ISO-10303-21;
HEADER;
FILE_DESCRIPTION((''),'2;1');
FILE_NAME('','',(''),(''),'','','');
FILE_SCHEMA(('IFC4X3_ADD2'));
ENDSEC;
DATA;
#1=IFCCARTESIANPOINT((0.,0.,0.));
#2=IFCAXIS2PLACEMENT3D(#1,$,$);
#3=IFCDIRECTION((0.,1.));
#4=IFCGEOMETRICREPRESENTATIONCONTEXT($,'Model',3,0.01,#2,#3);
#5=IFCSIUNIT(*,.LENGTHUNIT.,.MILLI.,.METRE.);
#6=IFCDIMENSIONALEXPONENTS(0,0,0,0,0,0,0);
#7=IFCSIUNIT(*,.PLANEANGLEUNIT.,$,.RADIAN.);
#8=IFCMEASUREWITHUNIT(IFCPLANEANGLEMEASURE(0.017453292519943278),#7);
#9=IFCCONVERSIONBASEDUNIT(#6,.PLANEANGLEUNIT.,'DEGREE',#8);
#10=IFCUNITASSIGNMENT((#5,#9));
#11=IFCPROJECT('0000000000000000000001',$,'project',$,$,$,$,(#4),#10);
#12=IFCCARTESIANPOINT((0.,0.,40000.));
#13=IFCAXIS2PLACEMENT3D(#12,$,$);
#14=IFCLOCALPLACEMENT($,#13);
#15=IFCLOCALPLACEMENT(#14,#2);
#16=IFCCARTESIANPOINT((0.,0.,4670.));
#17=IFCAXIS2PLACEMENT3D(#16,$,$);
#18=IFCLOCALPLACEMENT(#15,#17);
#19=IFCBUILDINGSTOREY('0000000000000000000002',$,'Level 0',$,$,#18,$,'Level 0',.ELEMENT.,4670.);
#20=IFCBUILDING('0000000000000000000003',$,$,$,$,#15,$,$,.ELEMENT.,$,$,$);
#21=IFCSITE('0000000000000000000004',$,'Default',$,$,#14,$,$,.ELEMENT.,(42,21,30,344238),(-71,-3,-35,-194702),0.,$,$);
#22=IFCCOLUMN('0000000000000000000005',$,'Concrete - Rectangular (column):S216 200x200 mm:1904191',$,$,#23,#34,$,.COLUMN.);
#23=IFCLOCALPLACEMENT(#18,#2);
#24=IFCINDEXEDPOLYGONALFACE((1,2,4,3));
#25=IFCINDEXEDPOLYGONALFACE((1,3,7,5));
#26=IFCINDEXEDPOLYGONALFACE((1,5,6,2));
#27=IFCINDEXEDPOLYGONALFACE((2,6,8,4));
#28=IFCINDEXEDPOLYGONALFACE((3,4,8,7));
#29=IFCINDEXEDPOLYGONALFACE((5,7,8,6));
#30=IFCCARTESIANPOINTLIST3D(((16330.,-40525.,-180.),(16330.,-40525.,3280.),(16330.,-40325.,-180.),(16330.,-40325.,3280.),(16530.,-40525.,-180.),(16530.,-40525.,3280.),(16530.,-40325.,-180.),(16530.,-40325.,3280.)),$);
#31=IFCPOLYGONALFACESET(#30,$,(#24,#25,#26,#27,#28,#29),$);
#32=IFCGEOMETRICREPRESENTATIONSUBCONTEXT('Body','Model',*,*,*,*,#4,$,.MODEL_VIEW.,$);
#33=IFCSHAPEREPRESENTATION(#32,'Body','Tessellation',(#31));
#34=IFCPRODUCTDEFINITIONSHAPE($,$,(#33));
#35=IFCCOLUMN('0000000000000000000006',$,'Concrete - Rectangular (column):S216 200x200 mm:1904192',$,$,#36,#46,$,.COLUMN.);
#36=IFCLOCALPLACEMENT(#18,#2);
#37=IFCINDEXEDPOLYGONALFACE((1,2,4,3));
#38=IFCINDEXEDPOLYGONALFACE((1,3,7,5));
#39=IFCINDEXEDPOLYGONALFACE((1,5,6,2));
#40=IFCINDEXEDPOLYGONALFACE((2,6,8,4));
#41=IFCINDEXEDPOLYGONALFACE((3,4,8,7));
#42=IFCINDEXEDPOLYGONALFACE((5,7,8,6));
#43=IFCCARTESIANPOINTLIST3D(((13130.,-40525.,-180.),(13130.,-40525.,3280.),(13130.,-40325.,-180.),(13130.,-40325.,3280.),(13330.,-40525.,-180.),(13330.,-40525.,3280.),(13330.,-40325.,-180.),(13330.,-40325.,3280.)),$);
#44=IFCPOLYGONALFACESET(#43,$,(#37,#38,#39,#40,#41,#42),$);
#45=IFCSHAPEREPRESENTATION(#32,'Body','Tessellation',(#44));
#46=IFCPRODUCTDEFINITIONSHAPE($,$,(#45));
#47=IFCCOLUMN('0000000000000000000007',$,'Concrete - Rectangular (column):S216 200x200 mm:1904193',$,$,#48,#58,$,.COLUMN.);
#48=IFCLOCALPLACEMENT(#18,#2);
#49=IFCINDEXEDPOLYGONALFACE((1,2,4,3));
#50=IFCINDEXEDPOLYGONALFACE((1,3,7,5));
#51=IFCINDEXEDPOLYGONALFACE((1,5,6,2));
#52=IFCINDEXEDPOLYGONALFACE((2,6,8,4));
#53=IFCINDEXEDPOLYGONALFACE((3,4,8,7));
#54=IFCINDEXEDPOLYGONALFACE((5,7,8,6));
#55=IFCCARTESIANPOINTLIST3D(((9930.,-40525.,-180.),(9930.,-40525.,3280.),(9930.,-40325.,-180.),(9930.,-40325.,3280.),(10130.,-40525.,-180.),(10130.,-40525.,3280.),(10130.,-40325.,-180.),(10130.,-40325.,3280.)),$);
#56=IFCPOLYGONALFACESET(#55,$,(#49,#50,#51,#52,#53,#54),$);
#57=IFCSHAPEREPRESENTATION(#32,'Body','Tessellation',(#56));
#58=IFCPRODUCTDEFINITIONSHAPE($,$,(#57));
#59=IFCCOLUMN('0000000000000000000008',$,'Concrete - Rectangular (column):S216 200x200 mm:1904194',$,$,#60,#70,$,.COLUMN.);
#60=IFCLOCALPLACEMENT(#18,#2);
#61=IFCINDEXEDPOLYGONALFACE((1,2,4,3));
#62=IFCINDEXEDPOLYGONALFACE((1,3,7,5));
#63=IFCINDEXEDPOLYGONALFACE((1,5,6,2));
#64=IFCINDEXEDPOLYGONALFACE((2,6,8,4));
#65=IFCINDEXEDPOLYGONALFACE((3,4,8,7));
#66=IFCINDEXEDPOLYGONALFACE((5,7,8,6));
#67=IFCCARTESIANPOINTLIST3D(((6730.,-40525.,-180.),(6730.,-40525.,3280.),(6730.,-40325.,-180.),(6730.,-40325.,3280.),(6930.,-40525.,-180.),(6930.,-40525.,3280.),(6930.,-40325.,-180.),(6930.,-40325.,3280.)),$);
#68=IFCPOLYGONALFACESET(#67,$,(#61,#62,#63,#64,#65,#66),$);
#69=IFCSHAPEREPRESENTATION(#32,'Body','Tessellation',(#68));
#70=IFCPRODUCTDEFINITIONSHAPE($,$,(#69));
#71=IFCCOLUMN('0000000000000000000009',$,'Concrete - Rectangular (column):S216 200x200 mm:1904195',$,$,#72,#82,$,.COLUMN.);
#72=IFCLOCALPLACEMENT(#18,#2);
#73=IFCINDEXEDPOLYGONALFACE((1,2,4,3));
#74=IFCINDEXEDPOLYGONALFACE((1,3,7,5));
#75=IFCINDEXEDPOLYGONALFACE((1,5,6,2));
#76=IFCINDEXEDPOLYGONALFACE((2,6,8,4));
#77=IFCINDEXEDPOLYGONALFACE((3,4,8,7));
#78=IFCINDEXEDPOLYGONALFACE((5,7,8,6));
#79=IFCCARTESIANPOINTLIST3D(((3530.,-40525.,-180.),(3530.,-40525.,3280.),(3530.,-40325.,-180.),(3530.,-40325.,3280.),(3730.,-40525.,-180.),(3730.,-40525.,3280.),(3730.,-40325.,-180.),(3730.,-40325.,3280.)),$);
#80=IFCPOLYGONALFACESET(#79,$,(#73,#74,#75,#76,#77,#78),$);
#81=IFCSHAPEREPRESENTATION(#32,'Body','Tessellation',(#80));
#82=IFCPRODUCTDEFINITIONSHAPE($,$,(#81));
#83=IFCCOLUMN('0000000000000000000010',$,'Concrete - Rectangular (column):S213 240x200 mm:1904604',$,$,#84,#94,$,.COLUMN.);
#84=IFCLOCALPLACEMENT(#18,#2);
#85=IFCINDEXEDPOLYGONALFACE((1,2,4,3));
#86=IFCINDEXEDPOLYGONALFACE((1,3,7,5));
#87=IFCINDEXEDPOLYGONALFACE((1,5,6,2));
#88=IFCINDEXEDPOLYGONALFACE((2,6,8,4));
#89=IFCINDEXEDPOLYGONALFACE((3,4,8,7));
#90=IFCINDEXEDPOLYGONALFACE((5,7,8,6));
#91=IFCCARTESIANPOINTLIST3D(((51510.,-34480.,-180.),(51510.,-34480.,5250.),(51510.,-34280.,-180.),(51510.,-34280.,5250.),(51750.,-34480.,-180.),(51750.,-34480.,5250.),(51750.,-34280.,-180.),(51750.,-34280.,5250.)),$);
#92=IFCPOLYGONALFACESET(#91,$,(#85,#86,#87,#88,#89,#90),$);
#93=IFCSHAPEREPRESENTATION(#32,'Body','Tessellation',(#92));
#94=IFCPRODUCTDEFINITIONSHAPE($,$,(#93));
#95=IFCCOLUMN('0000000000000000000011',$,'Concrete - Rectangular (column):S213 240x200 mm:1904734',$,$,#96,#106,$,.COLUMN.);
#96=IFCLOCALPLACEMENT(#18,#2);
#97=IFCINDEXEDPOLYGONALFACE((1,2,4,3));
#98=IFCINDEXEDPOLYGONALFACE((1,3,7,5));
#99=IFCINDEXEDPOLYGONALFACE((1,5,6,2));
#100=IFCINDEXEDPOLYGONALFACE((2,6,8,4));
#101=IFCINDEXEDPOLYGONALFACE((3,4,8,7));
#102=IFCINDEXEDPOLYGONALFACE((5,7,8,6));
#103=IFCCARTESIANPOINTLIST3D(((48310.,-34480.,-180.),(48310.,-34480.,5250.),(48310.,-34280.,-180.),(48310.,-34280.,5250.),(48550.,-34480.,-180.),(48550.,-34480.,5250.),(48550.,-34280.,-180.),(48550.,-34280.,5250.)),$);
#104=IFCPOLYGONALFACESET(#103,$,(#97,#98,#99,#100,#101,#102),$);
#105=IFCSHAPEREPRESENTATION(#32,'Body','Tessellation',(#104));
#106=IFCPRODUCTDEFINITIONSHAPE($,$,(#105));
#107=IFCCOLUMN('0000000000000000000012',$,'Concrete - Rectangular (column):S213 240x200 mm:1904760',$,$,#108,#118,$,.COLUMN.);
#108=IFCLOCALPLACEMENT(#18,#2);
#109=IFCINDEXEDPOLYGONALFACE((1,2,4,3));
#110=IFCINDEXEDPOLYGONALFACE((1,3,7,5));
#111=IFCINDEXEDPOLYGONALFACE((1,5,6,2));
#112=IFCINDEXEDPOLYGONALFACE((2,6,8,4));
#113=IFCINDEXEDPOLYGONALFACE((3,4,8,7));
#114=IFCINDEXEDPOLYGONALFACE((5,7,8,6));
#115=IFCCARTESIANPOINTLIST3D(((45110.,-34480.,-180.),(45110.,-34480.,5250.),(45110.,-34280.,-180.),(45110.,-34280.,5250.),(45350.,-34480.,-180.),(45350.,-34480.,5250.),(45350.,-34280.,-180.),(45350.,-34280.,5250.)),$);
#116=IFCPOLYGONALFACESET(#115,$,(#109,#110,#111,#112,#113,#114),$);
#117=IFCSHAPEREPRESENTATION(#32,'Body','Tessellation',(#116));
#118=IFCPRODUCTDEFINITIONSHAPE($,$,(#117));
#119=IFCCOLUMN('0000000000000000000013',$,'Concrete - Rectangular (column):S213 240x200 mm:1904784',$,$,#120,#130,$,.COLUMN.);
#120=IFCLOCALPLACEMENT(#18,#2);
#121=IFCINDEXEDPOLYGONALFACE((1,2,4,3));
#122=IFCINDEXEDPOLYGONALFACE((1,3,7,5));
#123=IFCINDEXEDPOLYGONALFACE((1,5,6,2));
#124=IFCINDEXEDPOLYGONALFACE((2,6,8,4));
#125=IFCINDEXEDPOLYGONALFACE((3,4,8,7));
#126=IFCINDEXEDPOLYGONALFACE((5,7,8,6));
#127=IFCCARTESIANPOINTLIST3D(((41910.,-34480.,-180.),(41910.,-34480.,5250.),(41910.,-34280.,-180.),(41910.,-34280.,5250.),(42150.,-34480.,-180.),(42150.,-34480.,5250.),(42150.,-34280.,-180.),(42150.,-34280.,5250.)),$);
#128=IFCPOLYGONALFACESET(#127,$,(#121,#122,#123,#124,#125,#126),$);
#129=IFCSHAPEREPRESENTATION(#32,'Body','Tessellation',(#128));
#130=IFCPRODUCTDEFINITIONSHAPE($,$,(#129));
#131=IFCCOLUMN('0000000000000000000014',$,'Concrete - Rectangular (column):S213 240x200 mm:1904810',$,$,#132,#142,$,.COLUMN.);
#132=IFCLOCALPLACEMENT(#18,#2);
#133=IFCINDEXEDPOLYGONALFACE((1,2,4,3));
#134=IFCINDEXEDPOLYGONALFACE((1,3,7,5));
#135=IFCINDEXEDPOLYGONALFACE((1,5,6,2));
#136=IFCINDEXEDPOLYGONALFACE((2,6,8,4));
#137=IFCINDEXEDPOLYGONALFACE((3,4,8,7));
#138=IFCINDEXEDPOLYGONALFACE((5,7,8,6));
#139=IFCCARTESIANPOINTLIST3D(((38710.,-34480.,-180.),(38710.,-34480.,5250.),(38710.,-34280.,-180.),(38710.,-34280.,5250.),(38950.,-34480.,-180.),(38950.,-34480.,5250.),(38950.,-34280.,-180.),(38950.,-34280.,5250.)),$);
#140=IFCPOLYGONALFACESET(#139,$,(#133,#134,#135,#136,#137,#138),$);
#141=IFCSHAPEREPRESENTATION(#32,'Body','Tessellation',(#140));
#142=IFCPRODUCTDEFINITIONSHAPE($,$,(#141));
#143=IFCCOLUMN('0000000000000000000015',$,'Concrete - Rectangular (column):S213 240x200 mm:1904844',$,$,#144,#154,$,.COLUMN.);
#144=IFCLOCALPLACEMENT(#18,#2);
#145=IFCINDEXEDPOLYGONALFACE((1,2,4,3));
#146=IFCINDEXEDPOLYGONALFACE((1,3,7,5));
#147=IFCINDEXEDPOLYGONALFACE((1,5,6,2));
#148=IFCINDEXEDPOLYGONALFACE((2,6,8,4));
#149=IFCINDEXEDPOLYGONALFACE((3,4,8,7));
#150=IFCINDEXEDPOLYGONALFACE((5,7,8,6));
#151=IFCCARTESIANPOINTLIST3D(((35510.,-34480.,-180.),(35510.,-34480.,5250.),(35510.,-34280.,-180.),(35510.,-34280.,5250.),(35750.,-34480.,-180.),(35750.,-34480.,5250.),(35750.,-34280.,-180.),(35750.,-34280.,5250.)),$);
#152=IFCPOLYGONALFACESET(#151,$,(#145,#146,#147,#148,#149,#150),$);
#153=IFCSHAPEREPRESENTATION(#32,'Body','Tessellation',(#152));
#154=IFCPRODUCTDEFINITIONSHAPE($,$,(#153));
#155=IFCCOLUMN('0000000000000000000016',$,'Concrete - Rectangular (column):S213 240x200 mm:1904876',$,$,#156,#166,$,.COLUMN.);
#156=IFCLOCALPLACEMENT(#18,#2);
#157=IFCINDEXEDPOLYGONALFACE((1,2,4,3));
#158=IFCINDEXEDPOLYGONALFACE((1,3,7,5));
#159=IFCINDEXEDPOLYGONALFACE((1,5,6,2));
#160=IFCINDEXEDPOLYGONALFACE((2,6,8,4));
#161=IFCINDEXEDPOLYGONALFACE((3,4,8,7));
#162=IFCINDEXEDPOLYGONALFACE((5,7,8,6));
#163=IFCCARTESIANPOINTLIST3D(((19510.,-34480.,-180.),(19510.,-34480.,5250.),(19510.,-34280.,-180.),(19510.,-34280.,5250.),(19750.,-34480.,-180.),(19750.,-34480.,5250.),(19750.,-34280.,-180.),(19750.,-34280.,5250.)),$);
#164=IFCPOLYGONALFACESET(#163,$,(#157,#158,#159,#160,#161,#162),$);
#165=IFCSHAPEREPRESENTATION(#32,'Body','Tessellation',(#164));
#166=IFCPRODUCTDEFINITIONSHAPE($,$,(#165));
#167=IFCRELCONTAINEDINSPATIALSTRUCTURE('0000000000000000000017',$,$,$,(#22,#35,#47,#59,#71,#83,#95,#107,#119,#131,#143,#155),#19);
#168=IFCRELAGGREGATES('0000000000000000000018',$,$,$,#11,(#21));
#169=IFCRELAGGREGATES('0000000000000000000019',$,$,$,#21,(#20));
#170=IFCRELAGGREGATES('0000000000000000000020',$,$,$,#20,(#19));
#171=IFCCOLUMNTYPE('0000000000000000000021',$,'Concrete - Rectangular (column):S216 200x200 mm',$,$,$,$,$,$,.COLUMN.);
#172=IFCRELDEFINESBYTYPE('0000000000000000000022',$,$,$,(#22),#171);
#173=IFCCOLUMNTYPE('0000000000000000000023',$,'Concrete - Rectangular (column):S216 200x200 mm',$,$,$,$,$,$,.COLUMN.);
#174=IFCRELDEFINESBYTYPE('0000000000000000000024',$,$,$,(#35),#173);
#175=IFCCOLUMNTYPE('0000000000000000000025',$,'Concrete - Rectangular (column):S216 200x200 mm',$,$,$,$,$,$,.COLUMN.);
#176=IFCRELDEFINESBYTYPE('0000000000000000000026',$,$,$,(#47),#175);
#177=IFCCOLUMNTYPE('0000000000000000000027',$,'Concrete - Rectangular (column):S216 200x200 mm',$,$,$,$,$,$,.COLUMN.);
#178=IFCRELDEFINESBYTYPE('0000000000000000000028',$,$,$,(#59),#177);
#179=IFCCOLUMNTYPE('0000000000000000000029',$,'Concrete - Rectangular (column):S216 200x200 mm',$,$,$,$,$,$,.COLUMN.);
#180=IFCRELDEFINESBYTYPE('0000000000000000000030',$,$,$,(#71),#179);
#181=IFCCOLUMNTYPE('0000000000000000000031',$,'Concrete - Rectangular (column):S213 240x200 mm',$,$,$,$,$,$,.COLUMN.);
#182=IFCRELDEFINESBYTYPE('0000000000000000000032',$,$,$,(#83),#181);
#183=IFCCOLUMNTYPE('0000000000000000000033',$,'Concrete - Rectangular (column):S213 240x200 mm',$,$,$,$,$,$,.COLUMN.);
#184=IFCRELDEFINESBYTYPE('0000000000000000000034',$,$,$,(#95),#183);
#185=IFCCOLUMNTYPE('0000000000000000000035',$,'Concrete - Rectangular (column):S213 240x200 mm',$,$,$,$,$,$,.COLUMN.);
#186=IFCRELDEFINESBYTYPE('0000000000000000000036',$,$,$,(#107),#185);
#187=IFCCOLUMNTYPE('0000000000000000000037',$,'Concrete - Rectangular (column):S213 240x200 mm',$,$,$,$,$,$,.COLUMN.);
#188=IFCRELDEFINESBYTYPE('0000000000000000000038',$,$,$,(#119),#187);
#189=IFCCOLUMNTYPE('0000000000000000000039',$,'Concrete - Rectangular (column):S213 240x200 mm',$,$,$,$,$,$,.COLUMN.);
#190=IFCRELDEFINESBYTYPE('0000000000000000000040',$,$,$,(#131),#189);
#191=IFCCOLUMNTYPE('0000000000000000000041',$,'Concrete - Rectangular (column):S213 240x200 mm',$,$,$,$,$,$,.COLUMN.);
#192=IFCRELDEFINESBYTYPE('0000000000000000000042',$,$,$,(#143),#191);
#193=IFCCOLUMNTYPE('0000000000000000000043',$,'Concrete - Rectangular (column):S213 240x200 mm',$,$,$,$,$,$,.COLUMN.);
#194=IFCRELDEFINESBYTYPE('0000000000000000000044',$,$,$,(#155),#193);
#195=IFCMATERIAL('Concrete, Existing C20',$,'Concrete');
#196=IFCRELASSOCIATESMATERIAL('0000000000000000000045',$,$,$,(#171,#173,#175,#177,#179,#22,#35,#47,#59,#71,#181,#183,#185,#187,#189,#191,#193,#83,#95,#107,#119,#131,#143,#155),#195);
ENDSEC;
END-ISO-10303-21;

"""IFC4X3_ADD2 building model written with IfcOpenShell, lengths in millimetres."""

from ifc_helpers import new_model, entity, si_unit, converted_unit, direction, frame, frame_2d, origin, origin_2d_with_axis, place, context, subcontext, project, spatial, rectangle, extrude, source, transform, mapped, material, material_profile, profile_set, profile_usage, type_object, type_shapes, element, save


model = new_model("IFC4X3_ADD2")

# Units and contexts
model_context = context("Model", 3, precision=0.01, world=origin(), true_north=direction((0.0, 1.0)))
body_context = subcontext(model_context, "Body", "Model", "MODEL_VIEW")
ifc_project = project(units=[si_unit("LENGTHUNIT", "METRE", prefix="MILLI"), converted_unit("PLANEANGLEUNIT", "DEGREE", entity("IfcPlaneAngleMeasure", 0.017453292519943278), si_unit("PLANEANGLEUNIT", "RADIAN"), dimensions=[0, 0, 0, 0, 0, 0, 0])], contexts=[model_context])

# Site, building, storey
site_placement = place(None, frame((0.0, 0.0, 40000.0)))
site = spatial("IfcSite", under=ifc_project, at=site_placement, Name="Default", CompositionType="ELEMENT", RefLatitude=(42, 21, 30, 344238), RefLongitude=(-71, -3, -35, -194702), RefElevation=0.0)
building_placement = place(site_placement, origin())
building = spatial("IfcBuilding", under=site, at=building_placement, CompositionType="ELEMENT")
storey_placement = place(building_placement, frame((0.0, 0.0, 4670.0)))
storey = spatial("IfcBuildingStorey", under=building, at=storey_placement, Name="Level 0", LongName="Level 0", CompositionType="ELEMENT", Elevation=4670.0)

# Columns
ifc_material = material(Name="Concrete, Existing C20", Category="Concrete")
ifc_material_profile_1 = material_profile(ifc_material, rectangle(XDim=200.0, YDim=200.0, at=frame_2d((0.0, 0.0), x_axis=(1.0, 0.0))), Name="S216 200x200 mm")
ifc_profile_set_1 = profile_set([ifc_material_profile_1], Name="S216 200x200 mm")
ifc_profile_usage_1 = profile_usage(ifc_profile_set_1)
column_type_1 = type_object("IfcColumnType", Name="Concrete - Rectangular (column):S216 200x200 mm", PredefinedType="COLUMN", material=ifc_profile_set_1)
shared_shape_1 = source(origin(), body_context, "Body", "SweptSolid", [
    extrude(rectangle(XDim=200.0, YDim=200.0, at=frame_2d((0.0, 0.0), x_axis=(1.0, 0.0))), frame((16430.0, -40425.0, 4490.0), z_axis=(0.0, 0.0, 1.0), x_axis=(0.0, 1.0, 0.0)), (0.0, 0.0, 1.0), 3460.0),
])
type_shapes(column_type_1, [shared_shape_1])
column_1_placement = place(storey_placement, frame((0.0, 0.0, -4670.0)))
element("IfcColumn", 1, at=column_1_placement, inside=storey, type_object=column_type_1, material=ifc_profile_usage_1, Name="Concrete - Rectangular (column):S216 200x200 mm:1904191", PredefinedType="COLUMN", context=body_context, shape_type="MappedRepresentation", body=[
    mapped(shared_shape_1, transform((0.0, 0.0, 0.0), scale=1.0)),
])
column_type_2 = type_object("IfcColumnType", Name="Concrete - Rectangular (column):S216 200x200 mm", PredefinedType="COLUMN", material=ifc_profile_set_1)
shared_shape_2 = source(origin(), body_context, "Body", "SweptSolid", [
    extrude(rectangle(XDim=200.0, YDim=200.0, at=frame_2d((0.0, 0.0), x_axis=(1.0, 0.0))), frame((13230.0, -40425.0, 4490.0), z_axis=(0.0, 0.0, 1.0), x_axis=(0.0, 1.0, 0.0)), (0.0, 0.0, 1.0), 3460.0),
])
type_shapes(column_type_2, [shared_shape_2])
column_2_placement = place(storey_placement, frame((0.0, 0.0, -4670.0)))
element("IfcColumn", 2, at=column_2_placement, inside=storey, type_object=column_type_2, material=ifc_profile_usage_1, Name="Concrete - Rectangular (column):S216 200x200 mm:1904192", PredefinedType="COLUMN", context=body_context, shape_type="MappedRepresentation", body=[
    mapped(shared_shape_2, transform((0.0, 0.0, 0.0), scale=1.0)),
])
column_type_3 = type_object("IfcColumnType", Name="Concrete - Rectangular (column):S216 200x200 mm", PredefinedType="COLUMN", material=ifc_profile_set_1)
shared_shape_3 = source(origin(), body_context, "Body", "SweptSolid", [
    extrude(rectangle(XDim=200.0, YDim=200.0, at=frame_2d((0.0, 0.0), x_axis=(1.0, 0.0))), frame((10030.0, -40425.0, 4490.0), z_axis=(0.0, 0.0, 1.0), x_axis=(0.0, 1.0, 0.0)), (0.0, 0.0, 1.0), 3460.0),
])
type_shapes(column_type_3, [shared_shape_3])
column_3_placement = place(storey_placement, frame((0.0, 0.0, -4670.0)))
element("IfcColumn", 3, at=column_3_placement, inside=storey, type_object=column_type_3, material=ifc_profile_usage_1, Name="Concrete - Rectangular (column):S216 200x200 mm:1904193", PredefinedType="COLUMN", context=body_context, shape_type="MappedRepresentation", body=[
    mapped(shared_shape_3, transform((0.0, 0.0, 0.0), scale=1.0)),
])
column_type_4 = type_object("IfcColumnType", Name="Concrete - Rectangular (column):S216 200x200 mm", PredefinedType="COLUMN", material=ifc_profile_set_1)
shared_shape_4 = source(origin(), body_context, "Body", "SweptSolid", [
    extrude(rectangle(XDim=200.0, YDim=200.0, at=frame_2d((0.0, 0.0), x_axis=(1.0, 0.0))), frame((6830.0, -40425.0, 4490.0), z_axis=(0.0, 0.0, 1.0), x_axis=(0.0, 1.0, 0.0)), (0.0, 0.0, 1.0), 3460.0),
])
type_shapes(column_type_4, [shared_shape_4])
column_4_placement = place(storey_placement, frame((0.0, 0.0, -4670.0)))
element("IfcColumn", 4, at=column_4_placement, inside=storey, type_object=column_type_4, material=ifc_profile_usage_1, Name="Concrete - Rectangular (column):S216 200x200 mm:1904194", PredefinedType="COLUMN", context=body_context, shape_type="MappedRepresentation", body=[
    mapped(shared_shape_4, transform((0.0, 0.0, 0.0), scale=1.0)),
])
column_type_5 = type_object("IfcColumnType", Name="Concrete - Rectangular (column):S216 200x200 mm", PredefinedType="COLUMN", material=ifc_profile_set_1)
shared_shape_5 = source(origin(), body_context, "Body", "SweptSolid", [
    extrude(rectangle(XDim=200.0, YDim=200.0, at=frame_2d((0.0, 0.0), x_axis=(1.0, 0.0))), frame((3630.0, -40425.0, 4490.0), z_axis=(0.0, 0.0, 1.0), x_axis=(0.0, 1.0, 0.0)), (0.0, 0.0, 1.0), 3460.0),
])
type_shapes(column_type_5, [shared_shape_5])
column_5_placement = place(storey_placement, frame((0.0, 0.0, -4670.0)))
element("IfcColumn", 5, at=column_5_placement, inside=storey, type_object=column_type_5, material=ifc_profile_usage_1, Name="Concrete - Rectangular (column):S216 200x200 mm:1904195", PredefinedType="COLUMN", context=body_context, shape_type="MappedRepresentation", body=[
    mapped(shared_shape_5, transform((0.0, 0.0, 0.0), scale=1.0)),
])
ifc_material_profile_2 = material_profile(ifc_material, rectangle(XDim=200.0, YDim=240.0, at=origin_2d_with_axis()), Name="S213 240x200 mm")
ifc_profile_set_2 = profile_set([ifc_material_profile_2], Name="S213 240x200 mm")
ifc_profile_usage_2 = profile_usage(ifc_profile_set_2)
column_type_6 = type_object("IfcColumnType", Name="Concrete - Rectangular (column):S213 240x200 mm", PredefinedType="COLUMN", material=ifc_profile_set_2)
shared_shape_6 = source(origin(), body_context, "Body", "SweptSolid", [
    extrude(rectangle(XDim=200.0, YDim=240.0, at=origin_2d_with_axis()), frame((51630.0, -34380.0, 4490.0), z_axis=(0.0, 0.0, 1.0), x_axis=(0.0, 1.0, 0.0)), (0.0, 0.0, 1.0), 5430.0),
])
type_shapes(column_type_6, [shared_shape_6])
column_6_placement = place(storey_placement, frame((0.0, 0.0, -4670.0)))
element("IfcColumn", 6, at=column_6_placement, inside=storey, type_object=column_type_6, material=ifc_profile_usage_2, Name="Concrete - Rectangular (column):S213 240x200 mm:1904604", PredefinedType="COLUMN", context=body_context, shape_type="MappedRepresentation", body=[
    mapped(shared_shape_6, transform((0.0, 0.0, 0.0), scale=1.0)),
])
column_type_7 = type_object("IfcColumnType", Name="Concrete - Rectangular (column):S213 240x200 mm", PredefinedType="COLUMN", material=ifc_profile_set_2)
shared_shape_7 = source(origin(), body_context, "Body", "SweptSolid", [
    extrude(rectangle(XDim=200.0, YDim=240.0, at=origin_2d_with_axis()), frame((48430.0, -34380.0, 4490.0), z_axis=(0.0, 0.0, 1.0), x_axis=(0.0, 1.0, 0.0)), (0.0, 0.0, 1.0), 5430.0),
])
type_shapes(column_type_7, [shared_shape_7])
column_7_placement = place(storey_placement, frame((0.0, 0.0, -4670.0)))
element("IfcColumn", 7, at=column_7_placement, inside=storey, type_object=column_type_7, material=ifc_profile_usage_2, Name="Concrete - Rectangular (column):S213 240x200 mm:1904734", PredefinedType="COLUMN", context=body_context, shape_type="MappedRepresentation", body=[
    mapped(shared_shape_7, transform((0.0, 0.0, 0.0), scale=1.0)),
])
column_type_8 = type_object("IfcColumnType", Name="Concrete - Rectangular (column):S213 240x200 mm", PredefinedType="COLUMN", material=ifc_profile_set_2)
shared_shape_8 = source(origin(), body_context, "Body", "SweptSolid", [
    extrude(rectangle(XDim=200.0, YDim=240.0, at=origin_2d_with_axis()), frame((45230.0, -34380.0, 4490.0), z_axis=(0.0, 0.0, 1.0), x_axis=(0.0, 1.0, 0.0)), (0.0, 0.0, 1.0), 5430.0),
])
type_shapes(column_type_8, [shared_shape_8])
column_8_placement = place(storey_placement, frame((0.0, 0.0, -4670.0)))
element("IfcColumn", 8, at=column_8_placement, inside=storey, type_object=column_type_8, material=ifc_profile_usage_2, Name="Concrete - Rectangular (column):S213 240x200 mm:1904760", PredefinedType="COLUMN", context=body_context, shape_type="MappedRepresentation", body=[
    mapped(shared_shape_8, transform((0.0, 0.0, 0.0), scale=1.0)),
])
column_type_9 = type_object("IfcColumnType", Name="Concrete - Rectangular (column):S213 240x200 mm", PredefinedType="COLUMN", material=ifc_profile_set_2)
shared_shape_9 = source(origin(), body_context, "Body", "SweptSolid", [
    extrude(rectangle(XDim=200.0, YDim=240.0, at=frame_2d((0.0, 0.0), x_axis=(1.0, 0.0))), frame((42030.0, -34380.0, 4490.0), z_axis=(0.0, 0.0, 1.0), x_axis=(0.0, 1.0, 0.0)), (0.0, 0.0, 1.0), 5430.0),
])
type_shapes(column_type_9, [shared_shape_9])
column_9_placement = place(storey_placement, frame((0.0, 0.0, -4670.0)))
element("IfcColumn", 9, at=column_9_placement, inside=storey, type_object=column_type_9, material=ifc_profile_usage_2, Name="Concrete - Rectangular (column):S213 240x200 mm:1904784", PredefinedType="COLUMN", context=body_context, shape_type="MappedRepresentation", body=[
    mapped(shared_shape_9, transform((0.0, 0.0, 0.0), scale=1.0)),
])
column_type_10 = type_object("IfcColumnType", Name="Concrete - Rectangular (column):S213 240x200 mm", PredefinedType="COLUMN", material=ifc_profile_set_2)
shared_shape_10 = source(origin(), body_context, "Body", "SweptSolid", [
    extrude(rectangle(XDim=200.0, YDim=240.0, at=frame_2d((0.0, 0.0), x_axis=(1.0, 0.0))), frame((38830.0, -34380.0, 4490.0), z_axis=(0.0, 0.0, 1.0), x_axis=(0.0, 1.0, 0.0)), (0.0, 0.0, 1.0), 5430.0),
])
type_shapes(column_type_10, [shared_shape_10])
column_10_placement = place(storey_placement, frame((0.0, 0.0, -4670.0)))
element("IfcColumn", 10, at=column_10_placement, inside=storey, type_object=column_type_10, material=ifc_profile_usage_2, Name="Concrete - Rectangular (column):S213 240x200 mm:1904810", PredefinedType="COLUMN", context=body_context, shape_type="MappedRepresentation", body=[
    mapped(shared_shape_10, transform((0.0, 0.0, 0.0), scale=1.0)),
])
column_type_11 = type_object("IfcColumnType", Name="Concrete - Rectangular (column):S213 240x200 mm", PredefinedType="COLUMN", material=ifc_profile_set_2)
shared_shape_11 = source(origin(), body_context, "Body", "SweptSolid", [
    extrude(rectangle(XDim=200.0, YDim=240.0, at=frame_2d((0.0, 0.0), x_axis=(1.0, 0.0))), frame((35630.0, -34380.0, 4490.0), z_axis=(0.0, 0.0, 1.0), x_axis=(0.0, 1.0, 0.0)), (0.0, 0.0, 1.0), 5430.0),
])
type_shapes(column_type_11, [shared_shape_11])
column_11_placement = place(storey_placement, frame((0.0, 0.0, -4670.0)))
element("IfcColumn", 11, at=column_11_placement, inside=storey, type_object=column_type_11, material=ifc_profile_usage_2, Name="Concrete - Rectangular (column):S213 240x200 mm:1904844", PredefinedType="COLUMN", context=body_context, shape_type="MappedRepresentation", body=[
    mapped(shared_shape_11, transform((0.0, 0.0, 0.0), scale=1.0)),
])
column_type_12 = type_object("IfcColumnType", Name="Concrete - Rectangular (column):S213 240x200 mm", PredefinedType="COLUMN", material=ifc_profile_set_2)
shared_shape_12 = source(origin(), body_context, "Body", "SweptSolid", [
    extrude(rectangle(XDim=200.0, YDim=240.0, at=frame_2d((0.0, 0.0), x_axis=(1.0, 0.0))), frame((19630.0, -34380.0, 4490.0), z_axis=(0.0, 0.0, 1.0), x_axis=(0.0, 1.0, 0.0)), (0.0, 0.0, 1.0), 5430.0),
])
type_shapes(column_type_12, [shared_shape_12])
column_12_placement = place(storey_placement, frame((0.0, 0.0, -4670.0)))
element("IfcColumn", 12, at=column_12_placement, inside=storey, type_object=column_type_12, material=ifc_profile_usage_2, Name="Concrete - Rectangular (column):S213 240x200 mm:1904876", PredefinedType="COLUMN", context=body_context, shape_type="MappedRepresentation", body=[
    mapped(shared_shape_12, transform((0.0, 0.0, 0.0), scale=1.0)),
])

save(model, "model.ifc")
